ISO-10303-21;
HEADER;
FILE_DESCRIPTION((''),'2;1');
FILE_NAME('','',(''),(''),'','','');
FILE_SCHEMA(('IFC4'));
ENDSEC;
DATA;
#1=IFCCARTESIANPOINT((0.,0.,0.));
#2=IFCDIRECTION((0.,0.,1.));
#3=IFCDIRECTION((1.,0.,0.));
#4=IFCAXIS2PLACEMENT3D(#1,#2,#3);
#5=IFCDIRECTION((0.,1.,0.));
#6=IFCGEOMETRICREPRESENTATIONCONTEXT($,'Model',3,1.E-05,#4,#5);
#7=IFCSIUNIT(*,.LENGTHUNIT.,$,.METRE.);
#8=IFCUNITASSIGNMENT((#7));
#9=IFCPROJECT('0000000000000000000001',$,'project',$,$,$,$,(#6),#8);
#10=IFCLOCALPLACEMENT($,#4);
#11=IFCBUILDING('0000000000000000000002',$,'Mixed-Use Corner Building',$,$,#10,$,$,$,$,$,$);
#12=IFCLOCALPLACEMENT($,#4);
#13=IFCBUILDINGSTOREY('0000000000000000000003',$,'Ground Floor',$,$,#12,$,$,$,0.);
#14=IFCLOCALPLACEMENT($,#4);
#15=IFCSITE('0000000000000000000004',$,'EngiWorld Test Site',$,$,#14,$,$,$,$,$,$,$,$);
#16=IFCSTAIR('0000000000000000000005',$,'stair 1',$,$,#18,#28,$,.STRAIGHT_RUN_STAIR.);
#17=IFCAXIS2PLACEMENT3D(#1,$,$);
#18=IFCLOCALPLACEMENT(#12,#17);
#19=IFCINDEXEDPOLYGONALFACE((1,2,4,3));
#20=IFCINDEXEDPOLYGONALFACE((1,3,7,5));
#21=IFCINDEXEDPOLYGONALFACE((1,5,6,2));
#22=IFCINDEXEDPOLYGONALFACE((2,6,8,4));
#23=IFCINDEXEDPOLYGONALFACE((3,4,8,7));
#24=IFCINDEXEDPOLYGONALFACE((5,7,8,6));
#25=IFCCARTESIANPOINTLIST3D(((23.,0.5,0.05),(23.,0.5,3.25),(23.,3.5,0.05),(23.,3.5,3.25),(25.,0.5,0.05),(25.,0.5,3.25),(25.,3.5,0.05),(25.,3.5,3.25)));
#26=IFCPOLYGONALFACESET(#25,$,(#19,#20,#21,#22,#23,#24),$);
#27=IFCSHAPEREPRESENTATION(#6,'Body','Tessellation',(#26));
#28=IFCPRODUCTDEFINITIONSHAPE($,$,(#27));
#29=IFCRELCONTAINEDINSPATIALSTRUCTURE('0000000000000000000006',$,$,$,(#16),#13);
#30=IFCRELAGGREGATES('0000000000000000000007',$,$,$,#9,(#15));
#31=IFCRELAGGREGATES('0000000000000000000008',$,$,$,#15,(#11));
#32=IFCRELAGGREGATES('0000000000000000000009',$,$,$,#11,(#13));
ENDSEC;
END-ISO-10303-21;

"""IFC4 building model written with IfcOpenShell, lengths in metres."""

from ifc_helpers import new_model, si_unit, direction, frame, origin_with_axes, origin_2d_with_axis, place, context, project, spatial, rectangle, extrude, element, save


model = new_model("IFC4")

# Units and contexts
model_context = context("Model", 3, precision=1e-05, world=origin_with_axes(), true_north=direction((0.0, 1.0, 0.0)))
ifc_project = project(units=[si_unit("LENGTHUNIT", "METRE")], contexts=[model_context])

# Site, building, storey
site_placement = place(None, origin_with_axes())
site = spatial("IfcSite", under=ifc_project, at=site_placement, Name="EngiWorld Test Site")
building_placement = place(None, origin_with_axes())
building = spatial("IfcBuilding", under=site, at=building_placement, Name="Mixed-Use Corner Building")
storey_placement = place(None, origin_with_axes())
storey = spatial("IfcBuildingStorey", under=building, at=storey_placement, Name="Ground Floor", Elevation=0.0)

# Stair
stair_placement = place(None, frame((24.0, 2.0, 0.05), z_axis=(0.0, 0.0, 1.0), x_axis=(1.0, 0.0, 0.0)))
element("IfcStair", 1, at=stair_placement, inside=storey, Name="stair 1", PredefinedType="STRAIGHT_RUN_STAIR", context=model_context, shape_type="SweptSolid", body=[
    extrude(rectangle(XDim=2.0, YDim=3.0, at=origin_2d_with_axis()), origin_with_axes(), (0.0, 0.0, 1.0), 3.2),
])

save(model, "model.ifc")
